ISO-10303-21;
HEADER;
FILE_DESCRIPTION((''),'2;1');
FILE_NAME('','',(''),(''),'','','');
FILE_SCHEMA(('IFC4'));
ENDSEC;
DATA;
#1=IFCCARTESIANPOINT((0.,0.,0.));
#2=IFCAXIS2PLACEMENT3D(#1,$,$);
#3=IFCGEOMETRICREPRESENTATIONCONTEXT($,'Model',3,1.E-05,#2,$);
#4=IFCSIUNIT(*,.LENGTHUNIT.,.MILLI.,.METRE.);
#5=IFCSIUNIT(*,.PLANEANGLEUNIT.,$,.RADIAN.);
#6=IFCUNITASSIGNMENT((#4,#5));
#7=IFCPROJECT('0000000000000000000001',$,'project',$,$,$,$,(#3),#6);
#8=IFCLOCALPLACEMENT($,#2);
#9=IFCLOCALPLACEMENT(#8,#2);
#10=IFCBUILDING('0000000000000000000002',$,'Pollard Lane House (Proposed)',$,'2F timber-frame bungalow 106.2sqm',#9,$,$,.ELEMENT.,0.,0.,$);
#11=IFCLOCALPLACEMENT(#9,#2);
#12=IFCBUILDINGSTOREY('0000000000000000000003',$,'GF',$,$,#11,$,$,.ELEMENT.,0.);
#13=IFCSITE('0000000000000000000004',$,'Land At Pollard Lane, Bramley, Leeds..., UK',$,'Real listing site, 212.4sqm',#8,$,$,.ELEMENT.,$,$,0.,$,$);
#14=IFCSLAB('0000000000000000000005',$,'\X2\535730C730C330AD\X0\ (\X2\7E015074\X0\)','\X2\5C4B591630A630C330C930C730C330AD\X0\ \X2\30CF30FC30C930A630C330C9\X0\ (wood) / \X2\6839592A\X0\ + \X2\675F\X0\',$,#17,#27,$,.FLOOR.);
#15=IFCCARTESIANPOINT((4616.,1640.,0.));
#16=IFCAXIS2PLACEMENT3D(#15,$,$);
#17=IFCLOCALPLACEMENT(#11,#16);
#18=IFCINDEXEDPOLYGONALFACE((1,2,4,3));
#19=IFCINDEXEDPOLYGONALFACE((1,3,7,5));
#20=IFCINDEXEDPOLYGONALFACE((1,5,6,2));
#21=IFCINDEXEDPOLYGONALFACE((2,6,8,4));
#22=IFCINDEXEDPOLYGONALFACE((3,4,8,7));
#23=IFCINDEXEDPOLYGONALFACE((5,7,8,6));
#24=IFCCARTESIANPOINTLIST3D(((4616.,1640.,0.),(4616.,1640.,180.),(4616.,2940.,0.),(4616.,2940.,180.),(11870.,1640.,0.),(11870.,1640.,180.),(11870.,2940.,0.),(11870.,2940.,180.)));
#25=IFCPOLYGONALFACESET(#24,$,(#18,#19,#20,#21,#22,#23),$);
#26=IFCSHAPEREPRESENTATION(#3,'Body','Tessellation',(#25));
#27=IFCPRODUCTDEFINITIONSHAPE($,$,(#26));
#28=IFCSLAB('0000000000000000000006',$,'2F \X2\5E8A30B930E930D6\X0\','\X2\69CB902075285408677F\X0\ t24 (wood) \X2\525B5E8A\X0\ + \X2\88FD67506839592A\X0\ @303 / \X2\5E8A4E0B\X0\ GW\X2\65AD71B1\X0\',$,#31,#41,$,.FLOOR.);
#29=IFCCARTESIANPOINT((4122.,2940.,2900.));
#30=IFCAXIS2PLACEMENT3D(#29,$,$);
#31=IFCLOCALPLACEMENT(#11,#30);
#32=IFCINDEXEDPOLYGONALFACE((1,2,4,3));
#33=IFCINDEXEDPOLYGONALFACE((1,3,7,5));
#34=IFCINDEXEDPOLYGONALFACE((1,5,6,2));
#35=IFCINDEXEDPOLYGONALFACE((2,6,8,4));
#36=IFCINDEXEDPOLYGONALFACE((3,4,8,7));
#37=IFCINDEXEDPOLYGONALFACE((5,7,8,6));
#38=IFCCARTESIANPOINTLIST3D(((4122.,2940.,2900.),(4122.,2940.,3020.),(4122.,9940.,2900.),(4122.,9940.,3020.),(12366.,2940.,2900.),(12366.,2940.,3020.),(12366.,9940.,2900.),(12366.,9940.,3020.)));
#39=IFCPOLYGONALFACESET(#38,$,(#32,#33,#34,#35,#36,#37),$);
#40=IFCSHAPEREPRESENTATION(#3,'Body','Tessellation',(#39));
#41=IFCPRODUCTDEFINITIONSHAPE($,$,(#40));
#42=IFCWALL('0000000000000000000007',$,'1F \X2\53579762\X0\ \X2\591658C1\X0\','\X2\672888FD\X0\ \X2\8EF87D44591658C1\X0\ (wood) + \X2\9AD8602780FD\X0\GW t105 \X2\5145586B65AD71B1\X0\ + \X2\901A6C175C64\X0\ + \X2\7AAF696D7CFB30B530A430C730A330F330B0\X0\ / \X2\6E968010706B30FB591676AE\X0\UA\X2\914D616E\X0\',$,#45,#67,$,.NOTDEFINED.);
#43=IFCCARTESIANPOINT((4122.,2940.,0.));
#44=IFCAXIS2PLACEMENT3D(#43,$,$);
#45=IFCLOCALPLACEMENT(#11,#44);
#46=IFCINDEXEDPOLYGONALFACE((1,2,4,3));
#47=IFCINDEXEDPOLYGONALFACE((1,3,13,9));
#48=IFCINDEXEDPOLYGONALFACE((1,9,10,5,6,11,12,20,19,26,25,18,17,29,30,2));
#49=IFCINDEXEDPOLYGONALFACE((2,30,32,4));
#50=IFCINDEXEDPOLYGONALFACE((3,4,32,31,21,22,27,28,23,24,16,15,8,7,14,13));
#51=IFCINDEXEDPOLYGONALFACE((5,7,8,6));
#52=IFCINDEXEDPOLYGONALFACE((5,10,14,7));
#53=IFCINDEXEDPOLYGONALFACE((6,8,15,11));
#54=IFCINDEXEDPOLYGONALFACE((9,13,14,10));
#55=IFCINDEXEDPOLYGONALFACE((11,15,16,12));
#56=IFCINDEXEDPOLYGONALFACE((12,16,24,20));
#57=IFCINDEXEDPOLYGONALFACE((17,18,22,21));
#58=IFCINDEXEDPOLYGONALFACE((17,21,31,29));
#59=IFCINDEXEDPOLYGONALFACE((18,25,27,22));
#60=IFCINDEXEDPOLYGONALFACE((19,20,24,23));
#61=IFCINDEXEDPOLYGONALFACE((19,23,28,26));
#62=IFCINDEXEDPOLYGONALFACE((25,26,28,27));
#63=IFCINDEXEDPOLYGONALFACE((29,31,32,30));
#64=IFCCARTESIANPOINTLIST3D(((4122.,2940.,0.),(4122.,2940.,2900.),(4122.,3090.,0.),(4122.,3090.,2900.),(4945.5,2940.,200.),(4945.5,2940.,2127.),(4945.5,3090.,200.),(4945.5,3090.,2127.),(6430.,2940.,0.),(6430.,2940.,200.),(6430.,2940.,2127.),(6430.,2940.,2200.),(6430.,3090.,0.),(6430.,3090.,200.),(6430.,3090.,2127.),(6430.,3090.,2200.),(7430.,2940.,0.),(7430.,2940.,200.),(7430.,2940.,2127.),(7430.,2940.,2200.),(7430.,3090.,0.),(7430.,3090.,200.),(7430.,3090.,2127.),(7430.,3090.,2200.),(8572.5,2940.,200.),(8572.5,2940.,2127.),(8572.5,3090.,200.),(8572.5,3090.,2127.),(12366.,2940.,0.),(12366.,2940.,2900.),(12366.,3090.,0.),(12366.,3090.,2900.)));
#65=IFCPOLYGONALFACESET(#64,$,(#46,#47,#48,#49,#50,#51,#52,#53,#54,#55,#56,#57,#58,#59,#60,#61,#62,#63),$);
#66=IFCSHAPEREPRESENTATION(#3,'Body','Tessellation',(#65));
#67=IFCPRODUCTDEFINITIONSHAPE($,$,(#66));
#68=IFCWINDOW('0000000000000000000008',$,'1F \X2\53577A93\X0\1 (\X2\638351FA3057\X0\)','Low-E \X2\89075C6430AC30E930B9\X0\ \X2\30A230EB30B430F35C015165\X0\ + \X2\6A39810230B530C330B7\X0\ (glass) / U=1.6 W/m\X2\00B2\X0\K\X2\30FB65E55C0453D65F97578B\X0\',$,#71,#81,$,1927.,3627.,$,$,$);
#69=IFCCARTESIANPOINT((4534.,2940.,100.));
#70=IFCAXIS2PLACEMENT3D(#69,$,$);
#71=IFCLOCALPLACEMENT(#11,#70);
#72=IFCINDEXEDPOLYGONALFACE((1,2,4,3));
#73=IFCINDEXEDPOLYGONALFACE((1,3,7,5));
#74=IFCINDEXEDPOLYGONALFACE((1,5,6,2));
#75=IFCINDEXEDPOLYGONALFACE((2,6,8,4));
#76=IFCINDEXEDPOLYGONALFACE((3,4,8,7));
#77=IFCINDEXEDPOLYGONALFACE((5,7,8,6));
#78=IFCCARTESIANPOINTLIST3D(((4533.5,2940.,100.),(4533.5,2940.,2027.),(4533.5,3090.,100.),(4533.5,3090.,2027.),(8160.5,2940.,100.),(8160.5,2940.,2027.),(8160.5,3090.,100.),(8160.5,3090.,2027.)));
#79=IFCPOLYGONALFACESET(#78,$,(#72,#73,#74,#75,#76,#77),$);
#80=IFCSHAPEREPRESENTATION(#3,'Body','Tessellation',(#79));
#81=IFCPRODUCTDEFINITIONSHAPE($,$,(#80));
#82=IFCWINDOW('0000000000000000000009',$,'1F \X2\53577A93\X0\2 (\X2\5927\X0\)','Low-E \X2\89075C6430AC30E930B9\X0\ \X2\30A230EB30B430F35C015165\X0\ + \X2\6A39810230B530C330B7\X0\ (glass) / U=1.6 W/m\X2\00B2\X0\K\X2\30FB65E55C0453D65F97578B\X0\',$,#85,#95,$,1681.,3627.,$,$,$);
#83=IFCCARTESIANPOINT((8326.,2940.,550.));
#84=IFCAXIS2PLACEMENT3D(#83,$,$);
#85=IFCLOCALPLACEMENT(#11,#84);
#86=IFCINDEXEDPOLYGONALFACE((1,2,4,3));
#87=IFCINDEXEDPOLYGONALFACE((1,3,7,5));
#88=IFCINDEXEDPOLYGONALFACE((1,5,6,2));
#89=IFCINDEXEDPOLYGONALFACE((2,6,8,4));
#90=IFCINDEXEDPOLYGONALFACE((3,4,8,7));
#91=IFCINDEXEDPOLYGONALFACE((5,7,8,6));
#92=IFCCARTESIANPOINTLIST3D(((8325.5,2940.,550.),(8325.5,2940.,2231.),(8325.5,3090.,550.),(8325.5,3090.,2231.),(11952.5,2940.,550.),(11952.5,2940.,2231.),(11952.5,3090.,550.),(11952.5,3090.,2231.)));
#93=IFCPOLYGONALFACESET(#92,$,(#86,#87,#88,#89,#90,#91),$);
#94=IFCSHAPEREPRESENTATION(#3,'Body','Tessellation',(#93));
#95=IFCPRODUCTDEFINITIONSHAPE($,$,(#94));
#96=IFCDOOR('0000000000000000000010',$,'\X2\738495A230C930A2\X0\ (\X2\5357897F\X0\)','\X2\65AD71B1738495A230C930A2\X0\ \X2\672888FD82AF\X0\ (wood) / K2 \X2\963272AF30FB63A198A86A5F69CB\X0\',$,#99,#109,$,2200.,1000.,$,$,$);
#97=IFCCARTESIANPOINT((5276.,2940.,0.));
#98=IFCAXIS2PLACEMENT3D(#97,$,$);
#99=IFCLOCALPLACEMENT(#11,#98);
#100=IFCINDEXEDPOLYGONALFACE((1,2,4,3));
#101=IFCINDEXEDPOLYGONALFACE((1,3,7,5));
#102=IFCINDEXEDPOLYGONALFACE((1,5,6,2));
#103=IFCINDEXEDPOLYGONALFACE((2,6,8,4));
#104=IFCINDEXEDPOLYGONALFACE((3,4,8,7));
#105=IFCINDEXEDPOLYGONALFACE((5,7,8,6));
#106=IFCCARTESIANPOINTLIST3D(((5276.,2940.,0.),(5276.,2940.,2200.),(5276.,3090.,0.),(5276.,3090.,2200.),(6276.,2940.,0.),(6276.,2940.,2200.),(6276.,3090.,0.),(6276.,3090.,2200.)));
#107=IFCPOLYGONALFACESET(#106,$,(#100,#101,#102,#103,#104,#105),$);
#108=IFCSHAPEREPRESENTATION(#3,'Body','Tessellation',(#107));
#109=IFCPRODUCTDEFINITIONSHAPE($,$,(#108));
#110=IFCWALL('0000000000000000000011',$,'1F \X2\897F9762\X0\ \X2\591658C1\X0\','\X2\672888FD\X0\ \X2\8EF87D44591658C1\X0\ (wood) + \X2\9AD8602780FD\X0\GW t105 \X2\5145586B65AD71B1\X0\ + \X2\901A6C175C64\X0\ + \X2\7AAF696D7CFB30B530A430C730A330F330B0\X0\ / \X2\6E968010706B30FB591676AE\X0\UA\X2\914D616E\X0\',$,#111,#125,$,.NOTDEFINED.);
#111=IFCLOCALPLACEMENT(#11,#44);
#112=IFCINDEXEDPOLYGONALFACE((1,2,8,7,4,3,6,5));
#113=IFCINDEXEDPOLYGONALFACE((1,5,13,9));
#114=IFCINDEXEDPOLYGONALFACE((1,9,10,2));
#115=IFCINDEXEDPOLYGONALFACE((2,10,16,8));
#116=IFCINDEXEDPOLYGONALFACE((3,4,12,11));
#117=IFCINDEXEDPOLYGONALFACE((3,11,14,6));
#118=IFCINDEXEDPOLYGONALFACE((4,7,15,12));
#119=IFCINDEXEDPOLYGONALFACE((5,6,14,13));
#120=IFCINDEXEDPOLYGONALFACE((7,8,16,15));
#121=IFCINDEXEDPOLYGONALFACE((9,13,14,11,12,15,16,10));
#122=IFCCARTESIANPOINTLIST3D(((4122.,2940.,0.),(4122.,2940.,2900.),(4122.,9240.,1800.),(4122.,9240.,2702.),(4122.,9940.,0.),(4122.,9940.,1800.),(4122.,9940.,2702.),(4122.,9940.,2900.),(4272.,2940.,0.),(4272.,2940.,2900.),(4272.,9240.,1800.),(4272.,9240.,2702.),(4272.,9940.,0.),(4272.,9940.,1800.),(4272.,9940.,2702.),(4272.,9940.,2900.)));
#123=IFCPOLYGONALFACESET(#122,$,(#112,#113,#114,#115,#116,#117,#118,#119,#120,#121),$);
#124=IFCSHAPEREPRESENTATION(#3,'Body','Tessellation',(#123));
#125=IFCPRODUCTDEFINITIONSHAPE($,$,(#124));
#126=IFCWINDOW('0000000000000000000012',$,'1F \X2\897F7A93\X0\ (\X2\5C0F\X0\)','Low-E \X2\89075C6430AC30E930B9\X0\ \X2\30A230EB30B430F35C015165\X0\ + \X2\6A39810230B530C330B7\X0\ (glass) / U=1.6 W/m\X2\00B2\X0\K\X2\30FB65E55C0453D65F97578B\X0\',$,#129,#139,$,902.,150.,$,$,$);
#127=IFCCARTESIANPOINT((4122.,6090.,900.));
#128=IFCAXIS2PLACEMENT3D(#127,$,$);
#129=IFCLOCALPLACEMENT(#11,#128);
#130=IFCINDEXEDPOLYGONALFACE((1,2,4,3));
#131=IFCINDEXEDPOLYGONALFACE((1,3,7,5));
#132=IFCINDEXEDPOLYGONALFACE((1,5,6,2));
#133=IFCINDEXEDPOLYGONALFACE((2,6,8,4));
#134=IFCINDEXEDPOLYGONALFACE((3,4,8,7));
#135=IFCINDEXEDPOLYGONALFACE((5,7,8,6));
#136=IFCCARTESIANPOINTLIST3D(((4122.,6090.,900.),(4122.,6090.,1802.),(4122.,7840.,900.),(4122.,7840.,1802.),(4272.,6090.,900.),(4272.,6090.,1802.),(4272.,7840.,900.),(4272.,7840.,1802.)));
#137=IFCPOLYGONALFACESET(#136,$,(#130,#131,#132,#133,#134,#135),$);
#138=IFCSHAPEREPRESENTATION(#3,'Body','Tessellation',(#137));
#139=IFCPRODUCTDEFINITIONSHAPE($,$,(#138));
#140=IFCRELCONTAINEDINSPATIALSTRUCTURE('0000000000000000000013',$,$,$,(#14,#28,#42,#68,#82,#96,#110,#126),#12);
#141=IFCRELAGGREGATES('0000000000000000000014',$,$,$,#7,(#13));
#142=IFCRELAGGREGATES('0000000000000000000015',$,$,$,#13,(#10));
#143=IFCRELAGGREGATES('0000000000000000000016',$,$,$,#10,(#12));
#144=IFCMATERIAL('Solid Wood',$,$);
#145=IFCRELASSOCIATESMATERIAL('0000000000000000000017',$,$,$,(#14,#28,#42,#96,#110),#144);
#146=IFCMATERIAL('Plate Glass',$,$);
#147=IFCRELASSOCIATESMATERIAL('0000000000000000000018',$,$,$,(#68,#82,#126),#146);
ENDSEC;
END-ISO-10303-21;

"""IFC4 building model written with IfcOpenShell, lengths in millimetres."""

from ifc_helpers import new_model, si_unit, frame, frame_2d, origin, place, context, project, spatial, rectangle, extrude, material, element, fill, save


model = new_model("IFC4")

# Units and contexts
model_context = context("Model", 3, precision=1e-05, world=origin())
ifc_project = project(units=[si_unit("LENGTHUNIT", "METRE", prefix="MILLI"), si_unit("PLANEANGLEUNIT", "RADIAN")], contexts=[model_context])

# Site, building, storey
site_placement = place(None, origin())
site = spatial("IfcSite", under=ifc_project, at=site_placement, Name="Land At Pollard Lane, Bramley, Leeds..., UK", ObjectType="Real listing site, 212.4sqm", CompositionType="ELEMENT", RefElevation=0.0)
building_placement = place(site_placement, origin())
building = spatial("IfcBuilding", under=site, at=building_placement, Name="Pollard Lane House (Proposed)", ObjectType="2F timber-frame bungalow 106.2sqm", CompositionType="ELEMENT", ElevationOfRefHeight=0.0, ElevationOfTerrain=0.0)
storey_placement = place(building_placement, origin())
storey = spatial("IfcBuildingStorey", under=building, at=storey_placement, Name="GF", CompositionType="ELEMENT", Elevation=0.0)

# Slabs
ifc_material_1 = material(Name="Solid Wood")
slab_1_placement = place(storey_placement, frame((4616.0, 1640.0, 0.0)))
element("IfcSlab", 1, at=slab_1_placement, inside=storey, material=ifc_material_1, Name="南デッキ (縁側)", Description="屋外ウッドデッキ ハードウッド (wood) / 根太 + 束", PredefinedType="FLOOR", context=model_context, shape_type="SweptSolid", body=[
    extrude(rectangle(XDim=7254.0, YDim=1300.0, at=frame_2d((3627.0, 650.0))), frame((4616.0, 1640.0, 0.0)), (0.0, 0.0, 1.0), 180.0),
])
slab_2_placement = place(storey_placement, frame((4122.0, 2940.0, 2900.0)))
element("IfcSlab", 2, at=slab_2_placement, inside=storey, material=ifc_material_1, Name="2F 床スラブ", Description="構造用合板 t24 (wood) 剛床 + 製材根太 @303 / 床下 GW断熱", PredefinedType="FLOOR", context=model_context, shape_type="SweptSolid", body=[
    extrude(rectangle(XDim=8244.0, YDim=7000.0, at=frame_2d((4122.0, 3500.0))), frame((4122.0, 2940.0, 2900.0)), (0.0, 0.0, 1.0), 120.0),
])

# Wall, openings, windows, door
wall_1_placement = place(storey_placement, frame((4122.0, 2940.0, 0.0)))
wall_1 = element("IfcWall", 3, at=wall_1_placement, inside=storey, material=ifc_material_1, Name="1F 南面 外壁", Description="木製 軸組外壁 (wood) + 高性能GW t105 充填断熱 + 通気層 + 窯業系サイディング / 準耐火・外皮UA配慮", PredefinedType="NOTDEFINED", context=model_context, shape_type="SweptSolid", body=[
    extrude(rectangle(XDim=8244.0, YDim=150.0, at=frame_2d((4122.0, 75.0))), frame((4122.0, 2940.0, 0.0)), (0.0, 0.0, 1.0), 2900.0),
])
opening_1_placement = place(storey_placement, frame((4534.0, 2940.0, 100.0)))
opening_1 = element("IfcOpeningElement", 4, at=opening_1_placement, cuts=wall_1, PredefinedType="NOTDEFINED", context=model_context, shape_type="SweptSolid", body=[
    extrude(rectangle(XDim=3627.0, YDim=150.0, at=frame_2d((1813.0, 75.0))), frame((4534.0, 2940.0, 100.0)), (0.0, 0.0, 1.0), 1927.0),
])
opening_2_placement = place(storey_placement, frame((8326.0, 2940.0, 550.0)))
opening_2 = element("IfcOpeningElement", 5, at=opening_2_placement, cuts=wall_1, PredefinedType="NOTDEFINED", context=model_context, shape_type="SweptSolid", body=[
    extrude(rectangle(XDim=3627.0, YDim=150.0, at=frame_2d((1813.0, 75.0))), frame((8326.0, 2940.0, 550.0)), (0.0, 0.0, 1.0), 1681.0),
])
opening_3_placement = place(storey_placement, frame((5276.0, 2940.0, 0.0)))
opening_3 = element("IfcOpeningElement", 6, at=opening_3_placement, cuts=wall_1, PredefinedType="NOTDEFINED", context=model_context, shape_type="SweptSolid", body=[
    extrude(rectangle(XDim=1000.0, YDim=150.0, at=frame_2d((500.0, 75.0))), frame((5276.0, 2940.0, 0.0)), (0.0, 0.0, 1.0), 2200.0),
])
ifc_material_2 = material(Name="Plate Glass")
window_1_placement = place(storey_placement, frame((4534.0, 2940.0, 100.0)))
window_1 = element("IfcWindow", 7, at=window_1_placement, inside=storey, material=ifc_material_2, Name="1F 南窓1 (掃出し)", Description="Low-E 複層ガラス アルゴン封入 + 樹脂サッシ (glass) / U=1.6 W/m²K・日射取得型", OverallHeight=1927.0, OverallWidth=3627.0, context=model_context, shape_type="SweptSolid", body=[
    extrude(rectangle(XDim=3627.0, YDim=150.0, at=frame_2d((1813.0, 75.0))), frame((4534.0, 2940.0, 100.0)), (0.0, 0.0, 1.0), 1927.0),
])
fill(opening_1, window_1)
window_2_placement = place(storey_placement, frame((8326.0, 2940.0, 550.0)))
window_2 = element("IfcWindow", 8, at=window_2_placement, inside=storey, material=ifc_material_2, Name="1F 南窓2 (大)", Description="Low-E 複層ガラス アルゴン封入 + 樹脂サッシ (glass) / U=1.6 W/m²K・日射取得型", OverallHeight=1681.0, OverallWidth=3627.0, context=model_context, shape_type="SweptSolid", body=[
    extrude(rectangle(XDim=3627.0, YDim=150.0, at=frame_2d((1813.0, 75.0))), frame((8326.0, 2940.0, 550.0)), (0.0, 0.0, 1.0), 1681.0),
])
fill(opening_2, window_2)
door_placement = place(storey_placement, frame((5276.0, 2940.0, 0.0)))
door = element("IfcDoor", 9, at=door_placement, inside=storey, material=ifc_material_1, Name="玄関ドア (南西)", Description="断熱玄関ドア 木製芯 (wood) / K2 防犯・採風機構", OverallHeight=2200.0, OverallWidth=1000.0, context=model_context, shape_type="SweptSolid", body=[
    extrude(rectangle(XDim=1000.0, YDim=150.0, at=frame_2d((500.0, 75.0))), frame((5276.0, 2940.0, 0.0)), (0.0, 0.0, 1.0), 2200.0),
])
fill(opening_3, door)

# Wall, opening, window
wall_2_placement = place(storey_placement, frame((4122.0, 2940.0, 0.0)))
wall_2 = element("IfcWall", 10, at=wall_2_placement, inside=storey, material=ifc_material_1, Name="1F 西面 外壁", Description="木製 軸組外壁 (wood) + 高性能GW t105 充填断熱 + 通気層 + 窯業系サイディング / 準耐火・外皮UA配慮", PredefinedType="NOTDEFINED", context=model_context, shape_type="SweptSolid", body=[
    extrude(rectangle(XDim=150.0, YDim=7000.0, at=frame_2d((75.0, 3500.0))), frame((4122.0, 2940.0, 0.0)), (0.0, 0.0, 1.0), 2900.0),
])
opening_4_placement = place(storey_placement, frame((4122.0, 6090.0, 900.0)))
opening_4 = element("IfcOpeningElement", 11, at=opening_4_placement, cuts=wall_2, PredefinedType="NOTDEFINED", context=model_context, shape_type="SweptSolid", body=[
    extrude(rectangle(XDim=150.0, YDim=1750.0, at=frame_2d((75.0, 875.0))), frame((4122.0, 6090.0, 900.0)), (0.0, 0.0, 1.0), 902.0),
])
window_3_placement = place(storey_placement, frame((4122.0, 6090.0, 900.0)))
window_3 = element("IfcWindow", 12, at=window_3_placement, inside=storey, material=ifc_material_2, Name="1F 西窓 (小)", Description="Low-E 複層ガラス アルゴン封入 + 樹脂サッシ (glass) / U=1.6 W/m²K・日射取得型", OverallHeight=902.0, OverallWidth=150.0, context=model_context, shape_type="SweptSolid", body=[
    extrude(rectangle(XDim=150.0, YDim=1750.0, at=frame_2d((75.0, 875.0))), frame((4122.0, 6090.0, 900.0)), (0.0, 0.0, 1.0), 902.0),
])
fill(opening_4, window_3)

save(model, "model.ifc")
